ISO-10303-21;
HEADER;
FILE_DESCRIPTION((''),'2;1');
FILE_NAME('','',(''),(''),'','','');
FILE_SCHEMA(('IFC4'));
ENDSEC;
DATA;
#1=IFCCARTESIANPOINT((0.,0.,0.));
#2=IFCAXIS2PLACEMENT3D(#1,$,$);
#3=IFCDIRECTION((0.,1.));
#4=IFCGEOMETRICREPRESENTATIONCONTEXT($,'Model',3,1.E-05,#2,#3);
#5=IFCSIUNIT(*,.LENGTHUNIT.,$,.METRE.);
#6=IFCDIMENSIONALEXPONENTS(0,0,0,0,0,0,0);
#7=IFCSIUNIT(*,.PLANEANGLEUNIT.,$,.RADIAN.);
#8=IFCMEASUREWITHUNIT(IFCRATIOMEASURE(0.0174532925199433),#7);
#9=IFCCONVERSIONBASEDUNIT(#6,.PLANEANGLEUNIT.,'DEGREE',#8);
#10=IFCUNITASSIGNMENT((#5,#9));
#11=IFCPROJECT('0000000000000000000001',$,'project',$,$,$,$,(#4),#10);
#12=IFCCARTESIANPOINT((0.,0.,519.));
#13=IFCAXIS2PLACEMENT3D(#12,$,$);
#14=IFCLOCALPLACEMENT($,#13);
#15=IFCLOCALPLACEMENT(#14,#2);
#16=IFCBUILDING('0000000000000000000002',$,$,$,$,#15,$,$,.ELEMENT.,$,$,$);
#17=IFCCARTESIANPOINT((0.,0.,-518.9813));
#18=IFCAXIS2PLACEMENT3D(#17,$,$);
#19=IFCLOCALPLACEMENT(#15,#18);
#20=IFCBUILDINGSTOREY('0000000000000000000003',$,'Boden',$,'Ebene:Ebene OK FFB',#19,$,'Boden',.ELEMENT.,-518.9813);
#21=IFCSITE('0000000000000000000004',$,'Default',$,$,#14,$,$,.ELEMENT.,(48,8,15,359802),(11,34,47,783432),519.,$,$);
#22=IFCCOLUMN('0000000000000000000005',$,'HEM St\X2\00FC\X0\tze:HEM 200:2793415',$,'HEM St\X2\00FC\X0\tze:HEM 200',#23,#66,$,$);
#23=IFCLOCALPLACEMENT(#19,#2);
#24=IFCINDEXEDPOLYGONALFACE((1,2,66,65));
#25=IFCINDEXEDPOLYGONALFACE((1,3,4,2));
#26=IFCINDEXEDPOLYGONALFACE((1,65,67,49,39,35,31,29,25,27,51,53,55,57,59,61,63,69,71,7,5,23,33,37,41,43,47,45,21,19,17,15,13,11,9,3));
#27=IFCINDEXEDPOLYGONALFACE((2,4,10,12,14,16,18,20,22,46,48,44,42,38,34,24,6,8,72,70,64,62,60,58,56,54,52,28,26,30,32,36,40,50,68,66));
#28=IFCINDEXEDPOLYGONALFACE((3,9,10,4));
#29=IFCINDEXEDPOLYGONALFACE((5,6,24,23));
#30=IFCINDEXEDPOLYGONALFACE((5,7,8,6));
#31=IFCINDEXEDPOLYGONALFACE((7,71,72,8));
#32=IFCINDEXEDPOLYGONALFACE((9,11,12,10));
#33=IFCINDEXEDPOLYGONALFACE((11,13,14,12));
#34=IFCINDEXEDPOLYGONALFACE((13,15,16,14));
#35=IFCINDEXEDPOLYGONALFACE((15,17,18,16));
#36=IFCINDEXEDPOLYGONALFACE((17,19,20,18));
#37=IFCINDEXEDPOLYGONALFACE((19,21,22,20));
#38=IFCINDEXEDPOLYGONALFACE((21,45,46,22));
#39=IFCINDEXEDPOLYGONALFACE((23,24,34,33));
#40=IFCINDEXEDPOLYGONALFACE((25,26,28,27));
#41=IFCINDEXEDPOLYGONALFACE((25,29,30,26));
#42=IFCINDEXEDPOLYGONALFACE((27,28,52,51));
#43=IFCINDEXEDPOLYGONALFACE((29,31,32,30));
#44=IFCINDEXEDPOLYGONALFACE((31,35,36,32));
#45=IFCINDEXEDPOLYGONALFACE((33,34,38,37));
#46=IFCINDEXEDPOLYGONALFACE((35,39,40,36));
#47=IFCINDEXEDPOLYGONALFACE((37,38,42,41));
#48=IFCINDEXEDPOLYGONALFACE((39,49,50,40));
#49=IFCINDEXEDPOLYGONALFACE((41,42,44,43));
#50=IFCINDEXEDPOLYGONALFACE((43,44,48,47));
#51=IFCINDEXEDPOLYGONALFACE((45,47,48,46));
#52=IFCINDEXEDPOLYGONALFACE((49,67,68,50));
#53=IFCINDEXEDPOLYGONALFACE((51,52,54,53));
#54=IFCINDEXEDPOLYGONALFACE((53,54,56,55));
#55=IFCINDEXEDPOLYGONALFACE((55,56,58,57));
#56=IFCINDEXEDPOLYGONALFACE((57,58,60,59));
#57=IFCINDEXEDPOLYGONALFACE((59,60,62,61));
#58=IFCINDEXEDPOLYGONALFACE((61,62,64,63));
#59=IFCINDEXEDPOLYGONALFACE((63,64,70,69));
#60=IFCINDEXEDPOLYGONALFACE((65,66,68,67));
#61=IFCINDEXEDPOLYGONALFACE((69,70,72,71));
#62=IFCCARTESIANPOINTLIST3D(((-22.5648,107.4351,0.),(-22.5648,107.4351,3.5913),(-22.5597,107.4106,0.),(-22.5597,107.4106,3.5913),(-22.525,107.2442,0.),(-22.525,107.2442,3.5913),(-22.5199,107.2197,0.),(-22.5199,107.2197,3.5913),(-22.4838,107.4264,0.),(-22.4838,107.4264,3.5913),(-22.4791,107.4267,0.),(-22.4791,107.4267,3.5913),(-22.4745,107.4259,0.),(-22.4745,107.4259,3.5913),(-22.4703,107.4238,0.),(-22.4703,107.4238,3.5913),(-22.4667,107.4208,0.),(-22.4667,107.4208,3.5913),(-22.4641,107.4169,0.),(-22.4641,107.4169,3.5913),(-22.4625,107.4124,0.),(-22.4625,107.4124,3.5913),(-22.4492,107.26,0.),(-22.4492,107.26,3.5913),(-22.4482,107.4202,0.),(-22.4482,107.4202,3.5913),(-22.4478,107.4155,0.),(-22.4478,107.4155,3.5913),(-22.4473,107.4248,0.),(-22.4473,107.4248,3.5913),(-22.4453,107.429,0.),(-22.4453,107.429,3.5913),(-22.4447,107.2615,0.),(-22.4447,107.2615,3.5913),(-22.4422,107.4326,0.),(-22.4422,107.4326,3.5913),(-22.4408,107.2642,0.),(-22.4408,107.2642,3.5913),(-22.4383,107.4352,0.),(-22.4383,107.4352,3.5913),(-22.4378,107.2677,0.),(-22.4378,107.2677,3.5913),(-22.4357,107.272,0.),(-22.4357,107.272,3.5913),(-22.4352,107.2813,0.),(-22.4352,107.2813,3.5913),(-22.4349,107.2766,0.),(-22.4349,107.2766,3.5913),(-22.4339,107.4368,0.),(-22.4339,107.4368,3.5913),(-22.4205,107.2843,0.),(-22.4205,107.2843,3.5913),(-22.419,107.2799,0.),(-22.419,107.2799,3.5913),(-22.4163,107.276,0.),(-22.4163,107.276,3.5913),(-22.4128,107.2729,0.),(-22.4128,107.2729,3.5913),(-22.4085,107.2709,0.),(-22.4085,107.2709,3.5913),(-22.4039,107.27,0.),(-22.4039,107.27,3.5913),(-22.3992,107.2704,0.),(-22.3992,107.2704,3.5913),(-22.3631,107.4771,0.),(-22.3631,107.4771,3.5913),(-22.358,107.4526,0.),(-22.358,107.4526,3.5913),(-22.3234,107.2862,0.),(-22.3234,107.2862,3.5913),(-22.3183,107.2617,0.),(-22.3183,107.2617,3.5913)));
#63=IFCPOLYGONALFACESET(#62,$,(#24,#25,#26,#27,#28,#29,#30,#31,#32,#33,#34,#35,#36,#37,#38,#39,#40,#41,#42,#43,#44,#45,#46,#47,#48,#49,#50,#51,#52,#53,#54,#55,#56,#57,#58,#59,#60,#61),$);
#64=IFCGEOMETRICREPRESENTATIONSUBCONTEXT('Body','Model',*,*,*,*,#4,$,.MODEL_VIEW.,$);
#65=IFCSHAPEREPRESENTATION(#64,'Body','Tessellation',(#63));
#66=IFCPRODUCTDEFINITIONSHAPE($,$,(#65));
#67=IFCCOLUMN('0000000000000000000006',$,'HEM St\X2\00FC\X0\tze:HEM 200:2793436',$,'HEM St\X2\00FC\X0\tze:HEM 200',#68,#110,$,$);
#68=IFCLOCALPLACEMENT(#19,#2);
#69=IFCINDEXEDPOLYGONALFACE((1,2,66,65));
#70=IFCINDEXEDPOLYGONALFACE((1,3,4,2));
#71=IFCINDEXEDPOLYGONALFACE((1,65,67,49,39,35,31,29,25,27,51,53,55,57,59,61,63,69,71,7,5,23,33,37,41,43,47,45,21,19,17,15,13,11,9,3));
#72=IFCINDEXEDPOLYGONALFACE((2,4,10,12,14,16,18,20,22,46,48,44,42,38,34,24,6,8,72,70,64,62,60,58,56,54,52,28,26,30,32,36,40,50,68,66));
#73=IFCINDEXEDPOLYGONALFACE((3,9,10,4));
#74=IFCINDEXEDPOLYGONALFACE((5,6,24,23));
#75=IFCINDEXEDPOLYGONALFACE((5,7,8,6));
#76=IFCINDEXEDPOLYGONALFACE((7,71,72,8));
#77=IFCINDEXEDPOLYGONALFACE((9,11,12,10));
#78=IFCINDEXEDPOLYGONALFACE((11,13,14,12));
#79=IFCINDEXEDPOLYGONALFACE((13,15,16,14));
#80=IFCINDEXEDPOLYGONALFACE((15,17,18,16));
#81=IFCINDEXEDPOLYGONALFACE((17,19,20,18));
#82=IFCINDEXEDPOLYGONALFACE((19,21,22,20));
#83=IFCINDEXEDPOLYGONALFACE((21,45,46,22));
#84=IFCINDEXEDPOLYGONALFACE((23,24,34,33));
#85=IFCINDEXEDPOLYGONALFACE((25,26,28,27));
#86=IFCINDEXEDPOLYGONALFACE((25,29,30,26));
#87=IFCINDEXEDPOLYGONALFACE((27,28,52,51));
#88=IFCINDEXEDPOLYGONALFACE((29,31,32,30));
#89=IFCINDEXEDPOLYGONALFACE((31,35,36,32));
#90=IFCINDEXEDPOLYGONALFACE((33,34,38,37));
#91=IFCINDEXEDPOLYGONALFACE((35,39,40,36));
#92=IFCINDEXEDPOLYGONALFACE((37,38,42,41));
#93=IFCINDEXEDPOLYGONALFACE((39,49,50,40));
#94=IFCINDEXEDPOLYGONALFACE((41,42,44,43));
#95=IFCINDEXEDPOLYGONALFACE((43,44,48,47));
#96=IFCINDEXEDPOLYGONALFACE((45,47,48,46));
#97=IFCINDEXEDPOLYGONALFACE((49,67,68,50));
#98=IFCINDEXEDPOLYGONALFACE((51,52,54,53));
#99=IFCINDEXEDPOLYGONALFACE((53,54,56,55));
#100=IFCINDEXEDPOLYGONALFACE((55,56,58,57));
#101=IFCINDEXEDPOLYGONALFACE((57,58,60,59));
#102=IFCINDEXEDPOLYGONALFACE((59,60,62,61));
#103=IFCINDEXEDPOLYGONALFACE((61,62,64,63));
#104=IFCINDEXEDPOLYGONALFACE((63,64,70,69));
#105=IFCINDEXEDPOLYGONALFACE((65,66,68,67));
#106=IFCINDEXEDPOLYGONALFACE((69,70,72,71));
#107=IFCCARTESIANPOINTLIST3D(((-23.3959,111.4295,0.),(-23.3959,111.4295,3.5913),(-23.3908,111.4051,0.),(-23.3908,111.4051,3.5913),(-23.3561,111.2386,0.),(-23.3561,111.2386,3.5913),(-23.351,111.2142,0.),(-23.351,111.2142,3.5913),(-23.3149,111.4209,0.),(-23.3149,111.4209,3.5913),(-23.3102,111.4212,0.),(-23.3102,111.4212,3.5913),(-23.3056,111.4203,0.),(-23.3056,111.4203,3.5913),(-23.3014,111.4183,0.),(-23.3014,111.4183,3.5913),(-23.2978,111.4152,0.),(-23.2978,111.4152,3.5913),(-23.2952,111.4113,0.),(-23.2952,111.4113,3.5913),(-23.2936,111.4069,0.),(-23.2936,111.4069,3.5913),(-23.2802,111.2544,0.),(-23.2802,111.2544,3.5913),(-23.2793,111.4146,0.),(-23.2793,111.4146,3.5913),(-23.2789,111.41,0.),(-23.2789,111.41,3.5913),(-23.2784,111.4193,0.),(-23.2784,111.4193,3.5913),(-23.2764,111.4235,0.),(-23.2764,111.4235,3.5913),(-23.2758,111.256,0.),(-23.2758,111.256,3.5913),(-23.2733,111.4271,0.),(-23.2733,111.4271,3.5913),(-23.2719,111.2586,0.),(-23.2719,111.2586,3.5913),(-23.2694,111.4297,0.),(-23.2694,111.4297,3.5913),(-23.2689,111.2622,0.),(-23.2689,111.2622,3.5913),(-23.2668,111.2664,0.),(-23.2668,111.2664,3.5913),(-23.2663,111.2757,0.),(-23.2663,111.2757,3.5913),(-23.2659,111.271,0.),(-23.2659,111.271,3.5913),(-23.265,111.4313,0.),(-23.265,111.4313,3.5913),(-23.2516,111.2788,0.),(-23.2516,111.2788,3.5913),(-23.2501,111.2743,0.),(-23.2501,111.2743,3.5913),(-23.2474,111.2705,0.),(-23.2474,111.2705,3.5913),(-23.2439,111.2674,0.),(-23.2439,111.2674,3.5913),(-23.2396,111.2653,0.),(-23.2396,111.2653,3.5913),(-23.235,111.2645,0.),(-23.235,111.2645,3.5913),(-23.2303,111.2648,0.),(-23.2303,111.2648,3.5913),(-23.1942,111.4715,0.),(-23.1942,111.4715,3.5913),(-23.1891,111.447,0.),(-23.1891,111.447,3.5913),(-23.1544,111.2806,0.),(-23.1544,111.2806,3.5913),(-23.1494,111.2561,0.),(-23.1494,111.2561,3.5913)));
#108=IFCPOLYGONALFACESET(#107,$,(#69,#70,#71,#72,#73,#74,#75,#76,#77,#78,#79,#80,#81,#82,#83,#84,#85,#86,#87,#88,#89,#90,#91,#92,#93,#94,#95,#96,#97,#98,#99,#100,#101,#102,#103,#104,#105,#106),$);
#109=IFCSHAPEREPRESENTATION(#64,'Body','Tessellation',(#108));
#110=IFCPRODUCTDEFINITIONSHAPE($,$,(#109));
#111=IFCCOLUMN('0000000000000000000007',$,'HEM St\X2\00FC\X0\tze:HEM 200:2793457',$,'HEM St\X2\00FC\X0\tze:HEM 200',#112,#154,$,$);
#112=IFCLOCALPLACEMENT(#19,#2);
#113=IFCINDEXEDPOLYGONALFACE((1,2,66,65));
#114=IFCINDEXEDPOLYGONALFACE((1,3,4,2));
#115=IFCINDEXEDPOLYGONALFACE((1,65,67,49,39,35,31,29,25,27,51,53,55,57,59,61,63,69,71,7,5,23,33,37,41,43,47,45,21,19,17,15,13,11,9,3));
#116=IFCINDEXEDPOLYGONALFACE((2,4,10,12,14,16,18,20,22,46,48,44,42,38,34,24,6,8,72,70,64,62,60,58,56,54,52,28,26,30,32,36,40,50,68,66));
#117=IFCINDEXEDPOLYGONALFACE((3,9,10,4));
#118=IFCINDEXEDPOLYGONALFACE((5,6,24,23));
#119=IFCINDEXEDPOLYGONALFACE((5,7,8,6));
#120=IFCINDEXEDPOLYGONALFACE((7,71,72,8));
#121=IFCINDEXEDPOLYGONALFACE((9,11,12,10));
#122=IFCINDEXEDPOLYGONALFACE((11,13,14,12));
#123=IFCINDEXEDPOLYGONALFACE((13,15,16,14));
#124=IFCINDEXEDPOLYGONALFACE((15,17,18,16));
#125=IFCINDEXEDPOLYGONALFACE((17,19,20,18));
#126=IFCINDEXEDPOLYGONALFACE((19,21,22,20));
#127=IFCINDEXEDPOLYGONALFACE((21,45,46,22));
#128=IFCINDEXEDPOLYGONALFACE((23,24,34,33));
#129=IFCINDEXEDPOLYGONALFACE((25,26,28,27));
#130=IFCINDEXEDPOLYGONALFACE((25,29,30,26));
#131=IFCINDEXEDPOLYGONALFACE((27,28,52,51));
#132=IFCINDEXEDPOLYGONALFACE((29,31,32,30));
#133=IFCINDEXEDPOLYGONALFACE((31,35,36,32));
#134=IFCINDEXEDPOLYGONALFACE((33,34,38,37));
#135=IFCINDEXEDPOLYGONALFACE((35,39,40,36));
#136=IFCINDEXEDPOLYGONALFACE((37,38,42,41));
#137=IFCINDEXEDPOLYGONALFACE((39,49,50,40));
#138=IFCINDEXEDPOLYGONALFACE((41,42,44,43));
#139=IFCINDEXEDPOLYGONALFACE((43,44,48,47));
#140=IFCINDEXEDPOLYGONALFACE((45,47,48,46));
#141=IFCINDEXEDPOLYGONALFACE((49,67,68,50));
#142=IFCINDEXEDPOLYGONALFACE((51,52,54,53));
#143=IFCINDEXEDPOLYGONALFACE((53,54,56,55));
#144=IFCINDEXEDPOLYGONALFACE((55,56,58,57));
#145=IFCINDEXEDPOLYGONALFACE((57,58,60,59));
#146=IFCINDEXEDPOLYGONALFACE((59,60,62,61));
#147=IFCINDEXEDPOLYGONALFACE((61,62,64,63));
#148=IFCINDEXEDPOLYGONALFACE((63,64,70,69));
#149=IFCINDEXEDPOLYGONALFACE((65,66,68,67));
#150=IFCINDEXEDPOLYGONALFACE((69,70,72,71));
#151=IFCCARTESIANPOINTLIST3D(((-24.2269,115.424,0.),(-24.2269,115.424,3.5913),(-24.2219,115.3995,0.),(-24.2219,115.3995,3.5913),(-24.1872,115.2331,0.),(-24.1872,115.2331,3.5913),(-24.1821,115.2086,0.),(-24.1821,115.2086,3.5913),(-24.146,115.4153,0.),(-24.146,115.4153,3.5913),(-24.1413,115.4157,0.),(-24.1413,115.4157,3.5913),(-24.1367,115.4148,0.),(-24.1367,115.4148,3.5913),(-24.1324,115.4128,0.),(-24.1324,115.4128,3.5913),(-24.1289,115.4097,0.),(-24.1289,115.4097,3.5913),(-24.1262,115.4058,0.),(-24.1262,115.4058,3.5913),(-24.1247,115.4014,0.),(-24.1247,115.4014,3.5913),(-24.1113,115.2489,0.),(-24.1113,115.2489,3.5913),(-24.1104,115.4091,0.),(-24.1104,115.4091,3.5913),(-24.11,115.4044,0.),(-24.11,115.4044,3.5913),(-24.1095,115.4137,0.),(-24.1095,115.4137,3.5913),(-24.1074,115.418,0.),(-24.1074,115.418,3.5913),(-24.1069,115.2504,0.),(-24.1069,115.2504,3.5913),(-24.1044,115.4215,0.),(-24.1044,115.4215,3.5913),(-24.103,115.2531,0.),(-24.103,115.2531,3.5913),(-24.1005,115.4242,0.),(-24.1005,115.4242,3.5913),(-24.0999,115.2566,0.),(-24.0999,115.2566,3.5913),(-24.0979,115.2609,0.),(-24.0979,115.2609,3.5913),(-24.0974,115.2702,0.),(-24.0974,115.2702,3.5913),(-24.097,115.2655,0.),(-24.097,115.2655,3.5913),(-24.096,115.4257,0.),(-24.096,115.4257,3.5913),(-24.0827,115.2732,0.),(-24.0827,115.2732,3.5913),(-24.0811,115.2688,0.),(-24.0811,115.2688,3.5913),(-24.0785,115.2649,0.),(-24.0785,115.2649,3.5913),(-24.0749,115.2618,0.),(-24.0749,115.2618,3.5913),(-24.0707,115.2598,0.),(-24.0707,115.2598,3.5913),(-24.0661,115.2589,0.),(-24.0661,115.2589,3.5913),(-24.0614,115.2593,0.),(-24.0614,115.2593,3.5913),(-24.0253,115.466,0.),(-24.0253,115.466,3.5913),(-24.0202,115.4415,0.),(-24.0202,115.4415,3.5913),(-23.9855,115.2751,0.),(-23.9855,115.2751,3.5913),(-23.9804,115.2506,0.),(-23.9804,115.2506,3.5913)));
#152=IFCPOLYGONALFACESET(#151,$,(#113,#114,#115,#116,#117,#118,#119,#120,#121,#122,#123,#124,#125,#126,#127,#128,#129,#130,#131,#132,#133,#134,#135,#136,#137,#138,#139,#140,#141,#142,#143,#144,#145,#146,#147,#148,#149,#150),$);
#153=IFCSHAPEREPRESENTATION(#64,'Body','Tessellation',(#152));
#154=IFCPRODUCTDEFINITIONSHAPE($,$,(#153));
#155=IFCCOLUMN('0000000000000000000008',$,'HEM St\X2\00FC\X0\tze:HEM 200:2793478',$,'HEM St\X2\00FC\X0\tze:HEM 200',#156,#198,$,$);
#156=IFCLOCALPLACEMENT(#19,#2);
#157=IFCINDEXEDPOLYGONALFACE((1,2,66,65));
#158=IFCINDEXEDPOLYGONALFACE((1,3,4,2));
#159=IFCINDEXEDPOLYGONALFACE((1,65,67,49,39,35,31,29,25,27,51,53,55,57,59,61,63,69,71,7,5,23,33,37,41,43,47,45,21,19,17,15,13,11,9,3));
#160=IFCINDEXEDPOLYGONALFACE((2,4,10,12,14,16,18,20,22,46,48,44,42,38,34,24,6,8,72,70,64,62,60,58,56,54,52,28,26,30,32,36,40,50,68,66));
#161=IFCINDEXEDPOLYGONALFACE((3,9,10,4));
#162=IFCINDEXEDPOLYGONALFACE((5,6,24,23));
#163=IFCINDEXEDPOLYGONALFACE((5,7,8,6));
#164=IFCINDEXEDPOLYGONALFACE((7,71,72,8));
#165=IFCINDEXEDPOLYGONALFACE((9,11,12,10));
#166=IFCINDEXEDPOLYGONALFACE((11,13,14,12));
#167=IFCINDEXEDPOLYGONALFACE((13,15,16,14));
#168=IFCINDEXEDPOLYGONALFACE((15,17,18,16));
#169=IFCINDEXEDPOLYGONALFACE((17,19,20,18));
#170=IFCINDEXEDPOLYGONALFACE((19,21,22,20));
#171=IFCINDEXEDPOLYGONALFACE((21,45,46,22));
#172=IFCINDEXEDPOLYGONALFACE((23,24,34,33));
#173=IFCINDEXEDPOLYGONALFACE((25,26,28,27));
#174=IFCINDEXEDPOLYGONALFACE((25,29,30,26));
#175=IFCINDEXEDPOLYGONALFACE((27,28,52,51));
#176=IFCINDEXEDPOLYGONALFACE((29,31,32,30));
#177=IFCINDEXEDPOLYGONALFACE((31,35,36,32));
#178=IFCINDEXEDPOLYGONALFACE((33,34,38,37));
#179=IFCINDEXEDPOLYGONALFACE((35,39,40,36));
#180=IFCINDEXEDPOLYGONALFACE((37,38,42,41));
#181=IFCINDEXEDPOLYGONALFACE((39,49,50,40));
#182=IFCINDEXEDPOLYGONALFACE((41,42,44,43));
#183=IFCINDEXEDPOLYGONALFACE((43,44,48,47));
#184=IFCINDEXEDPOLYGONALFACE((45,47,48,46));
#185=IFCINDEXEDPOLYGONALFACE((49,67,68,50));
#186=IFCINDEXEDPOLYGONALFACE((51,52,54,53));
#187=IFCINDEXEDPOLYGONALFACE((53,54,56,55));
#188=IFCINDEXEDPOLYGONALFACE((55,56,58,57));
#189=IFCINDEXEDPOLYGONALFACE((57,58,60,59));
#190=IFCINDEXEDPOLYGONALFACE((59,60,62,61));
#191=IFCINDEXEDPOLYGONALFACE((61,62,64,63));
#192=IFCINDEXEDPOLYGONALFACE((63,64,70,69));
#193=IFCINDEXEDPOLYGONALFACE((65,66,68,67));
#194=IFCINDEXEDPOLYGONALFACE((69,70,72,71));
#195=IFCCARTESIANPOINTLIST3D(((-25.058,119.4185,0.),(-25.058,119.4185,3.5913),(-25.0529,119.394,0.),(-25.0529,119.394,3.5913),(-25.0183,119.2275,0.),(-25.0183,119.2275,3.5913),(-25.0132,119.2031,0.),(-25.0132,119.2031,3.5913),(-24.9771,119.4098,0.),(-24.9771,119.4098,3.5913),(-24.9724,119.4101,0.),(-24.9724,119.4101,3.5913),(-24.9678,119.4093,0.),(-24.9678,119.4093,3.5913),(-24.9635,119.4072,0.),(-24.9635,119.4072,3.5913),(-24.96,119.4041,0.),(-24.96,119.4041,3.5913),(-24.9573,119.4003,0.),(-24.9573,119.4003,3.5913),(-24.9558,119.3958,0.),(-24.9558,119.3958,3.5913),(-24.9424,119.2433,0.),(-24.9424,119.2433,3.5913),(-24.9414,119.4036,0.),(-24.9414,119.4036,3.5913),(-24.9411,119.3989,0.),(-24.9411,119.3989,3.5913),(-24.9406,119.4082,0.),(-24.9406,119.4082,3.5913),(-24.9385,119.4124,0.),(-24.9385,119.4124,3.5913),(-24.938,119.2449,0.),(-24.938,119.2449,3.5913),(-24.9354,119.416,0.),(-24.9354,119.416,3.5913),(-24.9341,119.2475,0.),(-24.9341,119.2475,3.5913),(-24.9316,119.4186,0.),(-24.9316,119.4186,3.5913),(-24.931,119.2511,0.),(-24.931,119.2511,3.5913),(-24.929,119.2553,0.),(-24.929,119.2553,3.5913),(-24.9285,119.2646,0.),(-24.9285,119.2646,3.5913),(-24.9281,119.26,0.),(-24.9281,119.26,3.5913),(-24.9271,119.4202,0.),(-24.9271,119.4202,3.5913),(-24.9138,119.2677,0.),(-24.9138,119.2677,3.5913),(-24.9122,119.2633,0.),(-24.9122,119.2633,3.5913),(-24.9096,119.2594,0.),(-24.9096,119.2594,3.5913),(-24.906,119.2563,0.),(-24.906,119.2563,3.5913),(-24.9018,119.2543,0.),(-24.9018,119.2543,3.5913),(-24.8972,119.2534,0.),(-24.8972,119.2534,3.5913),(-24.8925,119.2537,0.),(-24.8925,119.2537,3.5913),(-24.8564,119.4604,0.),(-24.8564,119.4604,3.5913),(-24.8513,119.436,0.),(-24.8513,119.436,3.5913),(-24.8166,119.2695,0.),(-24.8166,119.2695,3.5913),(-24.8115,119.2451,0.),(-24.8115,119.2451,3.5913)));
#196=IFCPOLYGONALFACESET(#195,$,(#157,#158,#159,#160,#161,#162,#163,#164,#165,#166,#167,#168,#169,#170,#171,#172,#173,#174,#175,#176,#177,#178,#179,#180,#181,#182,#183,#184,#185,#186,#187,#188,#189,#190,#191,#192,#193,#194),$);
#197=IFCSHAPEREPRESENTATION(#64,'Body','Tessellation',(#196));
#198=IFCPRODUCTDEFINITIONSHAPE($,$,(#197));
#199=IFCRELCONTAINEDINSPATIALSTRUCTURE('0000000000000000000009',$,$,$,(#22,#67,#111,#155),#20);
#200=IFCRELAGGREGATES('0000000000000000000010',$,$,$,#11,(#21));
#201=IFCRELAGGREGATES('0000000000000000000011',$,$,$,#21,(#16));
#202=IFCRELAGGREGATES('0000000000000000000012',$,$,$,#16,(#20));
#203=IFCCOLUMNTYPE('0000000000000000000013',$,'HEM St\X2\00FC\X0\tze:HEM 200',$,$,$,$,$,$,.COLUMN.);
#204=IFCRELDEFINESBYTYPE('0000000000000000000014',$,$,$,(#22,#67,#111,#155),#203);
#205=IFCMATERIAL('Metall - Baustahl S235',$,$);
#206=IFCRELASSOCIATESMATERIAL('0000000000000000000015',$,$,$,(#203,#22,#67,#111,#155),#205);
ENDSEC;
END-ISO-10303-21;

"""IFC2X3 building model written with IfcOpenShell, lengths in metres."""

from ifc_helpers import new_model, entity, si_unit, converted_unit, direction, frame, frame_2d, origin, place, context, subcontext, project, spatial, polyline, circle_curve, parameter, trimmed, segment, composite_curve, outline, extrude, source, transform, mapped, material, type_object, type_shapes, element, save


model = new_model("IFC2X3")

# Units and contexts
model_context = context("Model", 3, precision=1e-05, world=origin(), true_north=direction((0.0, 1.0)))
body_context = subcontext(model_context, "Body", "Model", "MODEL_VIEW")
ifc_project = project(units=[si_unit("LENGTHUNIT", "METRE"), converted_unit("PLANEANGLEUNIT", "DEGREE", entity("IfcRatioMeasure", 0.0174532925199433), si_unit("PLANEANGLEUNIT", "RADIAN"), dimensions=[0, 0, 0, 0, 0, 0, 0])], contexts=[model_context])

# Site, building, storey
site_placement = place(None, frame((0.0, 0.0, 519.0)))
site = spatial("IfcSite", under=ifc_project, at=site_placement, Name="Default", CompositionType="ELEMENT", RefLatitude=(48, 8, 15, 359802), RefLongitude=(11, 34, 47, 783432), RefElevation=519.0)
building_placement = place(site_placement, origin())
building = spatial("IfcBuilding", under=site, at=building_placement, CompositionType="ELEMENT")
storey_placement = place(building_placement, frame((0.0, 0.0, -518.9813)))
storey = spatial("IfcBuildingStorey", under=building, at=storey_placement, Name="Boden", ObjectType="Ebene:Ebene OK FFB", LongName="Boden", CompositionType="ELEMENT", Elevation=-518.9813)

# Columns
ifc_material = material(Name="Metall - Baustahl S235")
column_type = type_object("IfcColumnType", Name="HEM Stütze:HEM 200", PredefinedType="COLUMN", material=ifc_material)
shared_shape = source(origin(), body_context, "Body", "SweptSolid", [
    extrude(outline(composite_curve([segment(polyline([(0.085, -0.103), (0.11, -0.103)]), True, "CONTINUOUS"), segment(polyline([(0.11, -0.103), (0.11, 0.103)]), True, "CONTINUOUS"), segment(polyline([(0.11, 0.103), (0.085, 0.103)]), True, "CONTINUOUS"), segment(polyline([(0.085, 0.103), (0.085, 0.0255)]), True, "CONTINUOUS"), segment(trimmed(circle_curve(frame_2d((0.067, 0.0255), x_axis=(1.0, 0.0)), 0.018), [parameter(270.0)], [parameter(0.0)], True, "PARAMETER"), False, "CONTINUOUS"), segment(polyline([(0.067, 0.0075), (-0.067, 0.0075)]), True, "CONTINUOUS"), segment(trimmed(circle_curve(frame_2d((-0.067, 0.0255), x_axis=(0.0, -1.0)), 0.018), [parameter(270.0)], [parameter(0.0)], True, "PARAMETER"), False, "CONTINUOUS"), segment(polyline([(-0.085, 0.0255), (-0.085, 0.103)]), True, "CONTINUOUS"), segment(polyline([(-0.085, 0.103), (-0.11, 0.103)]), True, "CONTINUOUS"), segment(polyline([(-0.11, 0.103), (-0.11, -0.103)]), True, "CONTINUOUS"), segment(polyline([(-0.11, -0.103), (-0.085, -0.103)]), True, "CONTINUOUS"), segment(polyline([(-0.085, -0.103), (-0.085, -0.0255)]), True, "CONTINUOUS"), segment(trimmed(circle_curve(frame_2d((-0.067, -0.0255), x_axis=(-1.0, 0.0)), 0.018), [parameter(270.0)], [parameter(0.0)], True, "PARAMETER"), False, "CONTINUOUS"), segment(polyline([(-0.067, -0.0075), (0.067, -0.0075)]), True, "CONTINUOUS"), segment(trimmed(circle_curve(frame_2d((0.067, -0.0255), x_axis=(0.0, 1.0)), 0.018), [parameter(270.0)], [parameter(0.0)], True, "PARAMETER"), False, "CONTINUOUS"), segment(polyline([(0.085, -0.0255), (0.085, -0.103)]), True, "CONTINUOUS")], self_intersect=False)), frame((0.0, 0.0, -518.9813), z_axis=(0.0, 0.0, 1.0), x_axis=(0.0, -1.0, 0.0)), (0.0, 0.0, 1.0), 3.5913),
])
type_shapes(column_type, [shared_shape])
for number, where, z_axis, x_axis, name in (
    (1, (-22.4415, 107.3484, 518.9813), (0.0, 0.0, 1.0), (0.979008, 0.20382, 0.0), "HEM Stütze:HEM 200:2793415"),
    (2, (-23.2726, 111.3428, 518.9813), (0.0, 0.0, 1.0), (0.979008, 0.20382, 0.0), "HEM Stütze:HEM 200:2793436"),
    (3, (-24.1037, 115.3373, 518.9813), (0.0, 0.0, 1.0), (0.979008, 0.20382, 0.0), "HEM Stütze:HEM 200:2793457"),
    (4, (-24.9348, 119.3318, 518.9813), (0.0, 0.0, 1.0), (0.979008, 0.20382, 0.0), "HEM Stütze:HEM 200:2793478"),
):
    element("IfcColumn", number, at=place(storey_placement, frame(where, z_axis=z_axis, x_axis=x_axis)), inside=storey, type_object=column_type, material=ifc_material, Name=name, ObjectType="HEM Stütze:HEM 200", context=body_context, shape_type="MappedRepresentation", body=[
        mapped(shared_shape, transform((0.0, 0.0, 0.0), scale=1.0)),
    ])

save(model, "model.ifc")
